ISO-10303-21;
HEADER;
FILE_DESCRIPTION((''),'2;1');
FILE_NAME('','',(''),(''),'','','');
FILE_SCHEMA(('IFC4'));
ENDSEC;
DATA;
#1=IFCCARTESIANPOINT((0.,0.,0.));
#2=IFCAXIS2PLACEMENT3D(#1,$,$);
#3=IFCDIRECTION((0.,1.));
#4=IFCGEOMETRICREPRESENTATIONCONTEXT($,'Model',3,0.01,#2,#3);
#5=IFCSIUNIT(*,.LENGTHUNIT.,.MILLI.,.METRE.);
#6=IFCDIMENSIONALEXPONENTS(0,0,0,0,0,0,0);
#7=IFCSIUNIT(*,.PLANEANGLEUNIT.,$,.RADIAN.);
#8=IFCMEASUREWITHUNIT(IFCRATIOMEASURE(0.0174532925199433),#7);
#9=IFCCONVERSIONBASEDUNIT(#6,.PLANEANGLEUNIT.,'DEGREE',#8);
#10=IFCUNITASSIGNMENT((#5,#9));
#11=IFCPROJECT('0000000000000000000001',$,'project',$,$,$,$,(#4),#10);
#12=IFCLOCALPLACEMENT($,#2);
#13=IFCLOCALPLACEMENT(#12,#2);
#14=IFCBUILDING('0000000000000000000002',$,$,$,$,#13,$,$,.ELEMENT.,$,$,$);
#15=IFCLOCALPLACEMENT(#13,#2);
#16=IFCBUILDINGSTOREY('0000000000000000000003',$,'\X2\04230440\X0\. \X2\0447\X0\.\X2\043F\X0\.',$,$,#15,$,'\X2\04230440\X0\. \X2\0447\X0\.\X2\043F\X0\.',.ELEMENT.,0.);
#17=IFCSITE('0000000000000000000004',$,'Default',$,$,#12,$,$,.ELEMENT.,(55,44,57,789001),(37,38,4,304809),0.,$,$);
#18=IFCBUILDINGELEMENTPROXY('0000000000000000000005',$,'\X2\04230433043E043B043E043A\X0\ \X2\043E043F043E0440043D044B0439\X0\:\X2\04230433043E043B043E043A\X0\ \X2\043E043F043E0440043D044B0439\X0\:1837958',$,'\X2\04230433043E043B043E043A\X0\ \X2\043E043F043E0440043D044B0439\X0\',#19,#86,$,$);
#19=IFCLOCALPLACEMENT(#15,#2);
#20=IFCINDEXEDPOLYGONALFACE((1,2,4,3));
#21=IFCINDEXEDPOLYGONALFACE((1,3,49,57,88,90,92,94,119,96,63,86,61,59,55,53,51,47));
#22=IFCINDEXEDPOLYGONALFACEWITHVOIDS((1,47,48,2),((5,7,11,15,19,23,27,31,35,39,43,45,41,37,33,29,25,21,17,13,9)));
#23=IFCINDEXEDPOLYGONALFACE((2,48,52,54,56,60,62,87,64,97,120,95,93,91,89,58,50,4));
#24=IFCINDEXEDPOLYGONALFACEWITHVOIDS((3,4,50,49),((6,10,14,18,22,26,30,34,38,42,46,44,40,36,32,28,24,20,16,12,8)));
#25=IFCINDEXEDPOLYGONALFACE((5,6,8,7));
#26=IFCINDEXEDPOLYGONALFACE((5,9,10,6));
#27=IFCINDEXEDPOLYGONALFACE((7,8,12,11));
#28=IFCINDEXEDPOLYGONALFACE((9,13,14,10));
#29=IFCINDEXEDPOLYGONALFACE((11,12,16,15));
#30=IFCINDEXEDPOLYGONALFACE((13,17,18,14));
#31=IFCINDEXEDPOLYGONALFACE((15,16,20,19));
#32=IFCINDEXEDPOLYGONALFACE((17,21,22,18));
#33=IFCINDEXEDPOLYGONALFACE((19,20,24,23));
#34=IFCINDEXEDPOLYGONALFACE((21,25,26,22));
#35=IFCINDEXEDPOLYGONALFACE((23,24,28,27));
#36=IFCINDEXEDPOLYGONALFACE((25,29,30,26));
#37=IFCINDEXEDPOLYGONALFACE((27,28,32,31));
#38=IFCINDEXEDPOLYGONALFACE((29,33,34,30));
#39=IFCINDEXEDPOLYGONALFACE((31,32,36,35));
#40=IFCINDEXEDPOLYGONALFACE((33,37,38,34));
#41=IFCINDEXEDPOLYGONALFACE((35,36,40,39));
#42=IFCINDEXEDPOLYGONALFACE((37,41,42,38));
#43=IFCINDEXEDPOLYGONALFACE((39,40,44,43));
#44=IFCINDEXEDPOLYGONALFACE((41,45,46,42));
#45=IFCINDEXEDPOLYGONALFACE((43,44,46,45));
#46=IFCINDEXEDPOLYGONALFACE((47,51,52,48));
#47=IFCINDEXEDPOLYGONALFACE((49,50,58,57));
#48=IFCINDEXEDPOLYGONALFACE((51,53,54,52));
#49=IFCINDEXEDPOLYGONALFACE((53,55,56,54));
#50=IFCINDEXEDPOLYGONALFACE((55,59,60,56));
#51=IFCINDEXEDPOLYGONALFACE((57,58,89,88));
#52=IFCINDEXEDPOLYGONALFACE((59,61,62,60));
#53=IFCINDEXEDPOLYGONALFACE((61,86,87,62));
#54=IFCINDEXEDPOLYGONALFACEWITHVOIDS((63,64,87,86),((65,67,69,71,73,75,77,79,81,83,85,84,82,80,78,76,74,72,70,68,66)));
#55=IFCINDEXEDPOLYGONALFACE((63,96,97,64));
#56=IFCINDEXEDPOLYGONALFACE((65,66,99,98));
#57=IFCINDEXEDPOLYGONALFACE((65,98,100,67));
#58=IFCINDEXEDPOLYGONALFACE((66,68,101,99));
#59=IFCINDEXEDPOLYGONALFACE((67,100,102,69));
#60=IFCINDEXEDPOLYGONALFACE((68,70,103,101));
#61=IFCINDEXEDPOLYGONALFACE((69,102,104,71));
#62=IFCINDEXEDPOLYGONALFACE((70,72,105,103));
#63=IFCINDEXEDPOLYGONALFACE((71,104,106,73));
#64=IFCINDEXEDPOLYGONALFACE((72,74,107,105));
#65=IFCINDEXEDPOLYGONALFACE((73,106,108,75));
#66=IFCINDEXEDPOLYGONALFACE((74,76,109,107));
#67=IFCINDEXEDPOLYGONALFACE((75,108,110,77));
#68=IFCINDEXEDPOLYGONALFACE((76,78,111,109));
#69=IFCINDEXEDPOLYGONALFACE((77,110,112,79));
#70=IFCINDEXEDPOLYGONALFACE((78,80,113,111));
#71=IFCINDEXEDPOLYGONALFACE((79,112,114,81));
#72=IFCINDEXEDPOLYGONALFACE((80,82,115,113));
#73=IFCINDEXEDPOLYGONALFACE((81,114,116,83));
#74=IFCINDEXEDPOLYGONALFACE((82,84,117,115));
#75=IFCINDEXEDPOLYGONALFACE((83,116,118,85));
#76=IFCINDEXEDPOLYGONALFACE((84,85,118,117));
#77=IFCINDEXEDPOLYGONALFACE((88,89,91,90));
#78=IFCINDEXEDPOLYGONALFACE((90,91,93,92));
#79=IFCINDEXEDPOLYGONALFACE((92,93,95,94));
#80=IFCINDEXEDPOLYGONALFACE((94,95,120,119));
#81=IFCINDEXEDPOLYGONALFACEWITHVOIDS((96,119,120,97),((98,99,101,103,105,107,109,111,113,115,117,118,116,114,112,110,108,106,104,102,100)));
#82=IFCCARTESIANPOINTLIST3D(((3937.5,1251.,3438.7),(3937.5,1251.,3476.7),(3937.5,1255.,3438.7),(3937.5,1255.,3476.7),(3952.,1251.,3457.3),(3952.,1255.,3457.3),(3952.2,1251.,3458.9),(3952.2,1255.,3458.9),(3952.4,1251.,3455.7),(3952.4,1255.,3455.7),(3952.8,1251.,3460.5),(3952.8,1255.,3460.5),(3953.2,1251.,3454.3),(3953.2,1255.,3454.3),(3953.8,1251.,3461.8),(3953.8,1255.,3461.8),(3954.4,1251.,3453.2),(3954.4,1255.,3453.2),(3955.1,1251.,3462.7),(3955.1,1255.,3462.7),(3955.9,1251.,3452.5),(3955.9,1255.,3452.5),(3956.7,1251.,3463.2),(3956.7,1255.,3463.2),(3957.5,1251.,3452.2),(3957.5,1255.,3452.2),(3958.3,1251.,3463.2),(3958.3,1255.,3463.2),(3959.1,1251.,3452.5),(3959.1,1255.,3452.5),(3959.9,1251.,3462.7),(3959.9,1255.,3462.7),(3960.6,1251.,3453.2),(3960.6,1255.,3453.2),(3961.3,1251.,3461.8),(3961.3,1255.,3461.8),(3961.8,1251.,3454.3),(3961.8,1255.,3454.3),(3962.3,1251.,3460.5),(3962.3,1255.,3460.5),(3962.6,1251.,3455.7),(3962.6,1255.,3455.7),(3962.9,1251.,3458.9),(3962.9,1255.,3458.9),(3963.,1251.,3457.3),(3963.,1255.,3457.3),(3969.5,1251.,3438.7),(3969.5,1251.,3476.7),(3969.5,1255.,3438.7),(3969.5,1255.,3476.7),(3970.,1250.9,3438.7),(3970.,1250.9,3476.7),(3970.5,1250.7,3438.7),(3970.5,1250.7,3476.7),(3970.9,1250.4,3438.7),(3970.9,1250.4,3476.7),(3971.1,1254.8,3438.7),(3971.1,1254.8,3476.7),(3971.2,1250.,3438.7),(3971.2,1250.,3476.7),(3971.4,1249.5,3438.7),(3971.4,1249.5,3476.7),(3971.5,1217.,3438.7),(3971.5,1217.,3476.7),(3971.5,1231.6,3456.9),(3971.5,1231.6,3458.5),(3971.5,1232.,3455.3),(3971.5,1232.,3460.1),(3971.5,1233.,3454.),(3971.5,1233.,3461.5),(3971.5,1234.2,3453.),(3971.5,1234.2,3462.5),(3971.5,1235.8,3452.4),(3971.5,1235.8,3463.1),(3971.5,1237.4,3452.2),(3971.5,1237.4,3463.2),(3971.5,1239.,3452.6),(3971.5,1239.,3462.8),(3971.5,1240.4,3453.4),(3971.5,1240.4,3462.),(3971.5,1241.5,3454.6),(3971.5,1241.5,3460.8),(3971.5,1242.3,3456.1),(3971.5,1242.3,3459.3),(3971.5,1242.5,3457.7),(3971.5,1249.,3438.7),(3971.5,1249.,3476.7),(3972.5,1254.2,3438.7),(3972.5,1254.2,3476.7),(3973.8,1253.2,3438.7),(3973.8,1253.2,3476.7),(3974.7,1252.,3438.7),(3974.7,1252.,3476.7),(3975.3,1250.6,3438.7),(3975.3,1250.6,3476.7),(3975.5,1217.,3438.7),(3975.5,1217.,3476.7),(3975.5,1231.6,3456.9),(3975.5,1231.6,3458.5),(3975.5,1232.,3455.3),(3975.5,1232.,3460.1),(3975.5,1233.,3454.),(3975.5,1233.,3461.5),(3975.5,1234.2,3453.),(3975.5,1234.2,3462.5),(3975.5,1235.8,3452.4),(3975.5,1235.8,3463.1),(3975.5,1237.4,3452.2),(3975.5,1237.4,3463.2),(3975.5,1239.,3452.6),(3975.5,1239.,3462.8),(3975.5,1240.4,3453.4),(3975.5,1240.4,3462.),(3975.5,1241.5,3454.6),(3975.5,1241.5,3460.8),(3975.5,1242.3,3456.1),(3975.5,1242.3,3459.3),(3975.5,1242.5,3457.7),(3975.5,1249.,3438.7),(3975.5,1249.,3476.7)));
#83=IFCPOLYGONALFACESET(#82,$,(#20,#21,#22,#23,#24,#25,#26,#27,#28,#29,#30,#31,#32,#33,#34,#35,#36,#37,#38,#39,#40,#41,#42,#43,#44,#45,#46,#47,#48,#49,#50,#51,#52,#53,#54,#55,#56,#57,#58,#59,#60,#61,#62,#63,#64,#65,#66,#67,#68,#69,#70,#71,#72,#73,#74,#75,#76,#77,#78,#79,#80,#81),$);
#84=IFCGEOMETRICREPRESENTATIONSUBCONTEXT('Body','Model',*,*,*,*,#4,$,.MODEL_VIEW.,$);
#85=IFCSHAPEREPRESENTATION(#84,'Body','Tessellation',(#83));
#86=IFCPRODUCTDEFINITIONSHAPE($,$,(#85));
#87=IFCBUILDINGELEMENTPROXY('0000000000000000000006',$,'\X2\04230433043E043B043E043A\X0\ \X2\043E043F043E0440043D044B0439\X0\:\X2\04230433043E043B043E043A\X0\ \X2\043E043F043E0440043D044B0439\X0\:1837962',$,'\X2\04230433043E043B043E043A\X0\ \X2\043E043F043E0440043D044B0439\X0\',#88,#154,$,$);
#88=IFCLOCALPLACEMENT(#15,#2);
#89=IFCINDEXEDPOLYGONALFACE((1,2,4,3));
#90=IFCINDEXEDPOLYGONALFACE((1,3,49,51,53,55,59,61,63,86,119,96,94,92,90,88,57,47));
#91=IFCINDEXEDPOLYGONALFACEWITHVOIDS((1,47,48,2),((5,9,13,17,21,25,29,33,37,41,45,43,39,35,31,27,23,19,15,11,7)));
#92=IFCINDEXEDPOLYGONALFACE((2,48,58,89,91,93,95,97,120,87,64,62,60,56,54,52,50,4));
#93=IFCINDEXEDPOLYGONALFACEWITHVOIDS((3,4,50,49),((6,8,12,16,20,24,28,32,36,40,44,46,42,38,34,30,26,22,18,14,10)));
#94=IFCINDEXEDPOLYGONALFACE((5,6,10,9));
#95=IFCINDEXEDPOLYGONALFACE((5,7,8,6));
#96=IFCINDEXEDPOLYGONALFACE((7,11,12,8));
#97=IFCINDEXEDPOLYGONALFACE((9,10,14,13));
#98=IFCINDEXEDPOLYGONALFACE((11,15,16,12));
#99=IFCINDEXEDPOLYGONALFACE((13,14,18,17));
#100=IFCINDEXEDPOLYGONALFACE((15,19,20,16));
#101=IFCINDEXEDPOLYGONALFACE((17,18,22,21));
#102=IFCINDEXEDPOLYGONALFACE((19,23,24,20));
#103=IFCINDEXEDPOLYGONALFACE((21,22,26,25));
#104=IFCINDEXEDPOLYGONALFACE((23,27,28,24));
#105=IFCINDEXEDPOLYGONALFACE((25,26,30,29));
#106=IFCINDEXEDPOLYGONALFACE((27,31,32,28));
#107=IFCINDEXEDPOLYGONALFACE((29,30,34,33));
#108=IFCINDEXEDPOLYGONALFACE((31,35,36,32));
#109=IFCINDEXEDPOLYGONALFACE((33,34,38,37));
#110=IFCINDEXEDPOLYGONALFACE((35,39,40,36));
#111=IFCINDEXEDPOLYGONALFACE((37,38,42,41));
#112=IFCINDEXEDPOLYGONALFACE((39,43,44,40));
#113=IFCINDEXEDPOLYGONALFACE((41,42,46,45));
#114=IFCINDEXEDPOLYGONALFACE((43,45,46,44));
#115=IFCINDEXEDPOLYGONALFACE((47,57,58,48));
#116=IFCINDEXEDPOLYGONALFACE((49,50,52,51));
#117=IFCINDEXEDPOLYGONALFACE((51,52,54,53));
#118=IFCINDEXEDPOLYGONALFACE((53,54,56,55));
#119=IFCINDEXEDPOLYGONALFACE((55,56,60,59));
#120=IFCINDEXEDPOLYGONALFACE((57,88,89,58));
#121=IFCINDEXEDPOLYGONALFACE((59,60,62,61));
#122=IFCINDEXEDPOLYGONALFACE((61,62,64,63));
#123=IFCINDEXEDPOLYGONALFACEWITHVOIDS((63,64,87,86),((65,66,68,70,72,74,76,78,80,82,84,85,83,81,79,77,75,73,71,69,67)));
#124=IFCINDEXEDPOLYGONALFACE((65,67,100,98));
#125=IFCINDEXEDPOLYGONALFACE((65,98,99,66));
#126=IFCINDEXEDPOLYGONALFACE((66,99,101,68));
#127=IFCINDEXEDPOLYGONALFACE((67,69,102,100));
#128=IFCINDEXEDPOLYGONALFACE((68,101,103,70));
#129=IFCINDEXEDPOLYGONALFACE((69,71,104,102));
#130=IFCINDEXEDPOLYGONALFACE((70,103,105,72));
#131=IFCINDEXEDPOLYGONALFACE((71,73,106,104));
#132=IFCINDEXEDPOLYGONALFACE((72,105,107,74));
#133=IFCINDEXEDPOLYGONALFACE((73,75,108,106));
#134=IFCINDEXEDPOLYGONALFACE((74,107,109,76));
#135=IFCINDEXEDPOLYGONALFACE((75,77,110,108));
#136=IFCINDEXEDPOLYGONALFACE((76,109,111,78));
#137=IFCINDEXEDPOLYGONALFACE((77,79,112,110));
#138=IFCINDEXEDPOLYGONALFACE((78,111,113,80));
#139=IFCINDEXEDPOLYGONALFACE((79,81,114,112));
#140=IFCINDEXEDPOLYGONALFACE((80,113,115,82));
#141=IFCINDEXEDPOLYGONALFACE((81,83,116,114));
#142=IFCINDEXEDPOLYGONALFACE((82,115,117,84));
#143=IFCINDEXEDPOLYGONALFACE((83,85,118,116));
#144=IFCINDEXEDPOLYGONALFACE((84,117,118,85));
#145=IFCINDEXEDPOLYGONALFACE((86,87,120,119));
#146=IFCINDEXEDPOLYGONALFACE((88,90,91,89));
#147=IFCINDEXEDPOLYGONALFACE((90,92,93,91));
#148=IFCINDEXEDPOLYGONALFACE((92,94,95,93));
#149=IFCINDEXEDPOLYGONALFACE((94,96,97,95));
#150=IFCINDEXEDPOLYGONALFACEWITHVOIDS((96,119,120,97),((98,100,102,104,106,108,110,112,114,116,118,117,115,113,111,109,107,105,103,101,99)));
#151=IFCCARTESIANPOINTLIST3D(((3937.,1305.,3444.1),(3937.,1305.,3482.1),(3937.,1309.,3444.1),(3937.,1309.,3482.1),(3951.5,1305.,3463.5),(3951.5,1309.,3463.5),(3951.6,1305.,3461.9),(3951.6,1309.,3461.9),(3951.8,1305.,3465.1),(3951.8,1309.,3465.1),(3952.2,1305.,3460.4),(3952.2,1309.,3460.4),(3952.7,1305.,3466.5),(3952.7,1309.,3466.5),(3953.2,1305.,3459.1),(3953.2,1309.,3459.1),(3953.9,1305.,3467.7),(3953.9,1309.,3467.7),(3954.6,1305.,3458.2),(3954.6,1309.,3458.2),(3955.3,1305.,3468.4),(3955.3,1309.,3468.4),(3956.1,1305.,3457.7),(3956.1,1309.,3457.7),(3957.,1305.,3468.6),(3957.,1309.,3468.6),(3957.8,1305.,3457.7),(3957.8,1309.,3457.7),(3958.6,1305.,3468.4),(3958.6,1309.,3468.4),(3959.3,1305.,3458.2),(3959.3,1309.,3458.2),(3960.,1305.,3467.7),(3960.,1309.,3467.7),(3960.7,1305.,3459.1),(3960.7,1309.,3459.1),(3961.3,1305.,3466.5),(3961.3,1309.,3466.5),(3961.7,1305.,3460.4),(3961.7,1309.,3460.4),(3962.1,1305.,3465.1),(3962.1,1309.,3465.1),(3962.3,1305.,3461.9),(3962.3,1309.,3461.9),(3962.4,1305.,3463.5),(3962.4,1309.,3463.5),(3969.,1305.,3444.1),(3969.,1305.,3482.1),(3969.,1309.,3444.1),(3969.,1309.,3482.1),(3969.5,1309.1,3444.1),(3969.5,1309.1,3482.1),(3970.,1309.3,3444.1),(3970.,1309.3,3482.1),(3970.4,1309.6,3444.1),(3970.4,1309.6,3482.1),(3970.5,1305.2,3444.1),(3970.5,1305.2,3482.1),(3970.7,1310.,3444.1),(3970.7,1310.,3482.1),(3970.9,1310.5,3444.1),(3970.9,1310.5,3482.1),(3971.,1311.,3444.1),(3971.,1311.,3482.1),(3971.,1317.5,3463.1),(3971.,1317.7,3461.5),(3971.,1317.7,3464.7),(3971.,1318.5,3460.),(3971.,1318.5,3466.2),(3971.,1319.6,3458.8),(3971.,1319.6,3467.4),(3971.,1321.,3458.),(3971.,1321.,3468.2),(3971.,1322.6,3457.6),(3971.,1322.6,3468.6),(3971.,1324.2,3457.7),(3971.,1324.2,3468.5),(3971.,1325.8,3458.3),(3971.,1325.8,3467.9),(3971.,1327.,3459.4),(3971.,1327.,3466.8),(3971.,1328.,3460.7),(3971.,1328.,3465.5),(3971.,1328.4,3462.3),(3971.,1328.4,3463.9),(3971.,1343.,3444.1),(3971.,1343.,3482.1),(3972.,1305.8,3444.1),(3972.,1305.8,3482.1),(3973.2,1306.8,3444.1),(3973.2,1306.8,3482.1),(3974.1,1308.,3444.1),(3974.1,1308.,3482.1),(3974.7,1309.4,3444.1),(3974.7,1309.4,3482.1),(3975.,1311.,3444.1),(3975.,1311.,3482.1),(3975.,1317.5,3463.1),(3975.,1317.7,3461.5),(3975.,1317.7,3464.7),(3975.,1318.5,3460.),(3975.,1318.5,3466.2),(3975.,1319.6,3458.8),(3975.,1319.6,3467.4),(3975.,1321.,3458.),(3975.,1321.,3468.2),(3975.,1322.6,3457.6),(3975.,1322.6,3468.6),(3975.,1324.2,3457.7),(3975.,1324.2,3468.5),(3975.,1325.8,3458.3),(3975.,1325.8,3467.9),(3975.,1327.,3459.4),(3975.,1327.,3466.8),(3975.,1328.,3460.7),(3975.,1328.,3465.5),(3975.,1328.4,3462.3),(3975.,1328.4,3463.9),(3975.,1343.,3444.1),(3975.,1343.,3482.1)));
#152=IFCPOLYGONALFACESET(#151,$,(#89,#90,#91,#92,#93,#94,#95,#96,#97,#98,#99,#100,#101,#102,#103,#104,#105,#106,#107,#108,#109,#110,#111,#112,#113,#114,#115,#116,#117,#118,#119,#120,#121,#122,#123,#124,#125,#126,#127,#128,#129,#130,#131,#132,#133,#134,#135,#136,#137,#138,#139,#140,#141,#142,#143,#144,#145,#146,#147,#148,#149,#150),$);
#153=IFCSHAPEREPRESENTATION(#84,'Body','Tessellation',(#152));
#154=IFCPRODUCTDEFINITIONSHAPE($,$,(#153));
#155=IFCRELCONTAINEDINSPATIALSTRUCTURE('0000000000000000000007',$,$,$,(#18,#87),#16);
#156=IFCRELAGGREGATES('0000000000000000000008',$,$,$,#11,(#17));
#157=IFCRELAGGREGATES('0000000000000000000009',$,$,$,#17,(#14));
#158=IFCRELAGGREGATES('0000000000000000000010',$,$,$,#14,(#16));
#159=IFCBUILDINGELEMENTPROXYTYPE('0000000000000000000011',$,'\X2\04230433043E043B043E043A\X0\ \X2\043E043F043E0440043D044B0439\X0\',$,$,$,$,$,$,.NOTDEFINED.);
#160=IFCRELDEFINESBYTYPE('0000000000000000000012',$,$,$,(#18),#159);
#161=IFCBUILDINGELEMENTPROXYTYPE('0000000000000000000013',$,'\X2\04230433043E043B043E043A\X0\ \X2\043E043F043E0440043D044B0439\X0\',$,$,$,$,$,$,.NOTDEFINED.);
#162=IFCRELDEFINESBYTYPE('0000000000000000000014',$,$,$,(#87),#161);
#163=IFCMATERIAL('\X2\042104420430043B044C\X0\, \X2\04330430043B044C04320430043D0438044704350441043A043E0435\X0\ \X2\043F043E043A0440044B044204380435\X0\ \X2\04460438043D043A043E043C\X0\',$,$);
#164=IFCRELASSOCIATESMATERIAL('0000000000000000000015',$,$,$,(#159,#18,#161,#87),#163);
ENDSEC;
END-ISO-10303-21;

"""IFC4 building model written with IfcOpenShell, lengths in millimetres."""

from ifc_helpers import new_model, entity, si_unit, converted_unit, direction, frame, frame_2d, origin, place, context, subcontext, project, spatial, polyline, circle_curve, parameter, trimmed, segment, composite_curve, circle, outline, extrude, source, transform, mapped, material, type_object, type_shapes, element, save


model = new_model("IFC4")

# Units and contexts
model_context = context("Model", 3, precision=0.01, world=origin(), true_north=direction((0.0, 1.0)))
body_context = subcontext(model_context, "Body", "Model", "MODEL_VIEW")
ifc_project = project(units=[si_unit("LENGTHUNIT", "METRE", prefix="MILLI"), converted_unit("PLANEANGLEUNIT", "DEGREE", entity("IfcRatioMeasure", 0.0174532925199433), si_unit("PLANEANGLEUNIT", "RADIAN"), dimensions=[0, 0, 0, 0, 0, 0, 0])], contexts=[model_context])

# Site, building, storey
site_placement = place(None, origin())
site = spatial("IfcSite", under=ifc_project, at=site_placement, Name="Default", CompositionType="ELEMENT", RefLatitude=(55, 44, 57, 789001), RefLongitude=(37, 38, 4, 304809), RefElevation=0.0)
building_placement = place(site_placement, origin())
building = spatial("IfcBuilding", under=site, at=building_placement, CompositionType="ELEMENT")
storey_placement = place(building_placement, origin())
storey = spatial("IfcBuildingStorey", under=building, at=storey_placement, Name="Ур. ч.п.", LongName="Ур. ч.п.", CompositionType="ELEMENT", Elevation=0.0)

# Building element proxies, openings
ifc_material = material(Name="Сталь, гальваническое покрытие цинком")
building_element_proxy_type_1 = type_object("IfcBuildingElementProxyType", Name="Уголок опорный", material=ifc_material)
shared_shape_1 = source(origin(), body_context, "Body", "SweptSolid", [
    extrude(outline(composite_curve([segment(polyline([(-6.0, -12.0), (26.0, -12.0)]), True, "CONTINUOUS"), segment(polyline([(26.0, -12.0), (26.0, -8.0)]), True, "CONTINUOUS"), segment(polyline([(26.0, -8.0), (-6.0, -8.0)]), True, "CONTINUOUS"), segment(trimmed(circle_curve(frame_2d((-6.0, -6.0), x_axis=(0.0, -1.0)), 2.0), [parameter(270.0)], [parameter(0.0)], True, "PARAMETER"), False, "CONTINUOUS"), segment(polyline([(-8.0, -6.0), (-8.0, 26.0)]), True, "CONTINUOUS"), segment(polyline([(-8.0, 26.0), (-12.0, 26.0)]), True, "CONTINUOUS"), segment(polyline([(-12.0, 26.0), (-12.0, -6.0)]), True, "CONTINUOUS"), segment(trimmed(circle_curve(frame_2d((-6.0, -6.0), x_axis=(0.0, -1.0)), 6.0), [parameter(270.0)], [parameter(360.0)], True, "PARAMETER"), True, "CONTINUOUS")], self_intersect=False)), frame((12.0, -19.0, 12.0), z_axis=(0.0, 1.0, 0.0), x_axis=(0.0, 0.0, 1.0)), (0.0, 0.0, 1.0), 38.0),
])
type_shapes(building_element_proxy_type_1, [shared_shape_1])
proxy_1_placement = place(storey_placement, frame((3975.5, 1255.0, 3457.7), z_axis=(0.0, -1.0, 0.0), x_axis=(-1.0, 0.0, 0.0)))
proxy_1 = element("IfcBuildingElementProxy", 1, at=proxy_1_placement, inside=storey, type_object=building_element_proxy_type_1, material=ifc_material, Name="Уголок опорный:Уголок опорный:1837958", ObjectType="Уголок опорный", context=body_context, shape_type="MappedRepresentation", body=[
    mapped(shared_shape_1, transform((0.0, 0.0, 0.0), scale=1.0)),
])
opening_1_placement = place(storey_placement, frame((3975.5, 1255.0, 3457.7)))
element("IfcOpeningElement", 2, at=opening_1_placement, cuts=proxy_1, ObjectType="Opening", PredefinedType="OPENING", context=body_context, shape_type="SweptSolid", body=[
    extrude(circle(Radius=5.5, at=frame_2d((0.0, 0.0), x_axis=(1.0, 0.0))), frame((0.0, -18.0, 0.0), z_axis=(-1.0, 0.0, 0.0), x_axis=(0.0, 1.0, 0.0)), (0.0, 0.0, 1.0), 4.0),
])
opening_2_placement = place(storey_placement, frame((3975.5, 1255.0, 3457.7)))
element("IfcOpeningElement", 3, at=opening_2_placement, cuts=proxy_1, ObjectType="Opening", PredefinedType="OPENING", context=body_context, shape_type="SweptSolid", body=[
    extrude(circle(Radius=5.5, at=frame_2d((0.0, 0.0), x_axis=(1.0, 0.0))), frame((-18.0, 0.0, 0.0), z_axis=(0.0, -1.0, 0.0), x_axis=(0.0, 0.0, -1.0)), (0.0, 0.0, 1.0), 4.0),
])
building_element_proxy_type_2 = type_object("IfcBuildingElementProxyType", Name="Уголок опорный", material=ifc_material)
shared_shape_2 = source(origin(), body_context, "Body", "SweptSolid", [
    extrude(outline(composite_curve([segment(polyline([(-6.0, -12.0), (26.0, -12.0)]), True, "CONTINUOUS"), segment(polyline([(26.0, -12.0), (26.0, -8.0)]), True, "CONTINUOUS"), segment(polyline([(26.0, -8.0), (-6.0, -8.0)]), True, "CONTINUOUS"), segment(trimmed(circle_curve(frame_2d((-6.0, -6.0), x_axis=(0.0, -1.0)), 2.0), [parameter(270.0)], [parameter(0.0)], True, "PARAMETER"), False, "CONTINUOUS"), segment(polyline([(-8.0, -6.0), (-8.0, 26.0)]), True, "CONTINUOUS"), segment(polyline([(-8.0, 26.0), (-12.0, 26.0)]), True, "CONTINUOUS"), segment(polyline([(-12.0, 26.0), (-12.0, -6.0)]), True, "CONTINUOUS"), segment(trimmed(circle_curve(frame_2d((-6.0, -6.0), x_axis=(0.0, -1.0)), 6.0), [parameter(270.0)], [parameter(360.0)], True, "PARAMETER"), True, "CONTINUOUS")], self_intersect=False)), frame((12.0, -19.0, 12.0), z_axis=(0.0, 1.0, 0.0), x_axis=(0.0, 0.0, 1.0)), (0.0, 0.0, 1.0), 38.0),
])
type_shapes(building_element_proxy_type_2, [shared_shape_2])
proxy_2_placement = place(storey_placement, frame((3975.0, 1305.0, 3463.1), z_axis=(0.0, 1.0, 0.0), x_axis=(-1.0, 0.0, 0.0)))
proxy_2 = element("IfcBuildingElementProxy", 4, at=proxy_2_placement, inside=storey, type_object=building_element_proxy_type_2, material=ifc_material, Name="Уголок опорный:Уголок опорный:1837962", ObjectType="Уголок опорный", context=body_context, shape_type="MappedRepresentation", body=[
    mapped(shared_shape_2, transform((0.0, 0.0, 0.0), scale=1.0)),
])
opening_3_placement = place(storey_placement, frame((3975.0, 1305.0, 3463.1)))
element("IfcOpeningElement", 5, at=opening_3_placement, cuts=proxy_2, ObjectType="Opening", PredefinedType="OPENING", context=body_context, shape_type="SweptSolid", body=[
    extrude(circle(Radius=5.5, at=frame_2d((0.0, 0.0), x_axis=(1.0, 0.0))), frame((-4.0, 18.0, 0.0), z_axis=(1.0, 0.0, 0.0), x_axis=(0.0, -1.0, 0.0)), (0.0, 0.0, 1.0), 4.0),
])
opening_4_placement = place(storey_placement, frame((3975.0, 1305.0, 3463.1)))
element("IfcOpeningElement", 6, at=opening_4_placement, cuts=proxy_2, ObjectType="Opening", PredefinedType="OPENING", context=body_context, shape_type="SweptSolid", body=[
    extrude(circle(Radius=5.5, at=frame_2d((0.0, 0.0), x_axis=(1.0, 0.0))), frame((-18.0, 0.0, 0.0), z_axis=(0.0, 1.0, 0.0), x_axis=(0.0, 0.0, 1.0)), (0.0, 0.0, 1.0), 4.0),
])

save(model, "model.ifc")
